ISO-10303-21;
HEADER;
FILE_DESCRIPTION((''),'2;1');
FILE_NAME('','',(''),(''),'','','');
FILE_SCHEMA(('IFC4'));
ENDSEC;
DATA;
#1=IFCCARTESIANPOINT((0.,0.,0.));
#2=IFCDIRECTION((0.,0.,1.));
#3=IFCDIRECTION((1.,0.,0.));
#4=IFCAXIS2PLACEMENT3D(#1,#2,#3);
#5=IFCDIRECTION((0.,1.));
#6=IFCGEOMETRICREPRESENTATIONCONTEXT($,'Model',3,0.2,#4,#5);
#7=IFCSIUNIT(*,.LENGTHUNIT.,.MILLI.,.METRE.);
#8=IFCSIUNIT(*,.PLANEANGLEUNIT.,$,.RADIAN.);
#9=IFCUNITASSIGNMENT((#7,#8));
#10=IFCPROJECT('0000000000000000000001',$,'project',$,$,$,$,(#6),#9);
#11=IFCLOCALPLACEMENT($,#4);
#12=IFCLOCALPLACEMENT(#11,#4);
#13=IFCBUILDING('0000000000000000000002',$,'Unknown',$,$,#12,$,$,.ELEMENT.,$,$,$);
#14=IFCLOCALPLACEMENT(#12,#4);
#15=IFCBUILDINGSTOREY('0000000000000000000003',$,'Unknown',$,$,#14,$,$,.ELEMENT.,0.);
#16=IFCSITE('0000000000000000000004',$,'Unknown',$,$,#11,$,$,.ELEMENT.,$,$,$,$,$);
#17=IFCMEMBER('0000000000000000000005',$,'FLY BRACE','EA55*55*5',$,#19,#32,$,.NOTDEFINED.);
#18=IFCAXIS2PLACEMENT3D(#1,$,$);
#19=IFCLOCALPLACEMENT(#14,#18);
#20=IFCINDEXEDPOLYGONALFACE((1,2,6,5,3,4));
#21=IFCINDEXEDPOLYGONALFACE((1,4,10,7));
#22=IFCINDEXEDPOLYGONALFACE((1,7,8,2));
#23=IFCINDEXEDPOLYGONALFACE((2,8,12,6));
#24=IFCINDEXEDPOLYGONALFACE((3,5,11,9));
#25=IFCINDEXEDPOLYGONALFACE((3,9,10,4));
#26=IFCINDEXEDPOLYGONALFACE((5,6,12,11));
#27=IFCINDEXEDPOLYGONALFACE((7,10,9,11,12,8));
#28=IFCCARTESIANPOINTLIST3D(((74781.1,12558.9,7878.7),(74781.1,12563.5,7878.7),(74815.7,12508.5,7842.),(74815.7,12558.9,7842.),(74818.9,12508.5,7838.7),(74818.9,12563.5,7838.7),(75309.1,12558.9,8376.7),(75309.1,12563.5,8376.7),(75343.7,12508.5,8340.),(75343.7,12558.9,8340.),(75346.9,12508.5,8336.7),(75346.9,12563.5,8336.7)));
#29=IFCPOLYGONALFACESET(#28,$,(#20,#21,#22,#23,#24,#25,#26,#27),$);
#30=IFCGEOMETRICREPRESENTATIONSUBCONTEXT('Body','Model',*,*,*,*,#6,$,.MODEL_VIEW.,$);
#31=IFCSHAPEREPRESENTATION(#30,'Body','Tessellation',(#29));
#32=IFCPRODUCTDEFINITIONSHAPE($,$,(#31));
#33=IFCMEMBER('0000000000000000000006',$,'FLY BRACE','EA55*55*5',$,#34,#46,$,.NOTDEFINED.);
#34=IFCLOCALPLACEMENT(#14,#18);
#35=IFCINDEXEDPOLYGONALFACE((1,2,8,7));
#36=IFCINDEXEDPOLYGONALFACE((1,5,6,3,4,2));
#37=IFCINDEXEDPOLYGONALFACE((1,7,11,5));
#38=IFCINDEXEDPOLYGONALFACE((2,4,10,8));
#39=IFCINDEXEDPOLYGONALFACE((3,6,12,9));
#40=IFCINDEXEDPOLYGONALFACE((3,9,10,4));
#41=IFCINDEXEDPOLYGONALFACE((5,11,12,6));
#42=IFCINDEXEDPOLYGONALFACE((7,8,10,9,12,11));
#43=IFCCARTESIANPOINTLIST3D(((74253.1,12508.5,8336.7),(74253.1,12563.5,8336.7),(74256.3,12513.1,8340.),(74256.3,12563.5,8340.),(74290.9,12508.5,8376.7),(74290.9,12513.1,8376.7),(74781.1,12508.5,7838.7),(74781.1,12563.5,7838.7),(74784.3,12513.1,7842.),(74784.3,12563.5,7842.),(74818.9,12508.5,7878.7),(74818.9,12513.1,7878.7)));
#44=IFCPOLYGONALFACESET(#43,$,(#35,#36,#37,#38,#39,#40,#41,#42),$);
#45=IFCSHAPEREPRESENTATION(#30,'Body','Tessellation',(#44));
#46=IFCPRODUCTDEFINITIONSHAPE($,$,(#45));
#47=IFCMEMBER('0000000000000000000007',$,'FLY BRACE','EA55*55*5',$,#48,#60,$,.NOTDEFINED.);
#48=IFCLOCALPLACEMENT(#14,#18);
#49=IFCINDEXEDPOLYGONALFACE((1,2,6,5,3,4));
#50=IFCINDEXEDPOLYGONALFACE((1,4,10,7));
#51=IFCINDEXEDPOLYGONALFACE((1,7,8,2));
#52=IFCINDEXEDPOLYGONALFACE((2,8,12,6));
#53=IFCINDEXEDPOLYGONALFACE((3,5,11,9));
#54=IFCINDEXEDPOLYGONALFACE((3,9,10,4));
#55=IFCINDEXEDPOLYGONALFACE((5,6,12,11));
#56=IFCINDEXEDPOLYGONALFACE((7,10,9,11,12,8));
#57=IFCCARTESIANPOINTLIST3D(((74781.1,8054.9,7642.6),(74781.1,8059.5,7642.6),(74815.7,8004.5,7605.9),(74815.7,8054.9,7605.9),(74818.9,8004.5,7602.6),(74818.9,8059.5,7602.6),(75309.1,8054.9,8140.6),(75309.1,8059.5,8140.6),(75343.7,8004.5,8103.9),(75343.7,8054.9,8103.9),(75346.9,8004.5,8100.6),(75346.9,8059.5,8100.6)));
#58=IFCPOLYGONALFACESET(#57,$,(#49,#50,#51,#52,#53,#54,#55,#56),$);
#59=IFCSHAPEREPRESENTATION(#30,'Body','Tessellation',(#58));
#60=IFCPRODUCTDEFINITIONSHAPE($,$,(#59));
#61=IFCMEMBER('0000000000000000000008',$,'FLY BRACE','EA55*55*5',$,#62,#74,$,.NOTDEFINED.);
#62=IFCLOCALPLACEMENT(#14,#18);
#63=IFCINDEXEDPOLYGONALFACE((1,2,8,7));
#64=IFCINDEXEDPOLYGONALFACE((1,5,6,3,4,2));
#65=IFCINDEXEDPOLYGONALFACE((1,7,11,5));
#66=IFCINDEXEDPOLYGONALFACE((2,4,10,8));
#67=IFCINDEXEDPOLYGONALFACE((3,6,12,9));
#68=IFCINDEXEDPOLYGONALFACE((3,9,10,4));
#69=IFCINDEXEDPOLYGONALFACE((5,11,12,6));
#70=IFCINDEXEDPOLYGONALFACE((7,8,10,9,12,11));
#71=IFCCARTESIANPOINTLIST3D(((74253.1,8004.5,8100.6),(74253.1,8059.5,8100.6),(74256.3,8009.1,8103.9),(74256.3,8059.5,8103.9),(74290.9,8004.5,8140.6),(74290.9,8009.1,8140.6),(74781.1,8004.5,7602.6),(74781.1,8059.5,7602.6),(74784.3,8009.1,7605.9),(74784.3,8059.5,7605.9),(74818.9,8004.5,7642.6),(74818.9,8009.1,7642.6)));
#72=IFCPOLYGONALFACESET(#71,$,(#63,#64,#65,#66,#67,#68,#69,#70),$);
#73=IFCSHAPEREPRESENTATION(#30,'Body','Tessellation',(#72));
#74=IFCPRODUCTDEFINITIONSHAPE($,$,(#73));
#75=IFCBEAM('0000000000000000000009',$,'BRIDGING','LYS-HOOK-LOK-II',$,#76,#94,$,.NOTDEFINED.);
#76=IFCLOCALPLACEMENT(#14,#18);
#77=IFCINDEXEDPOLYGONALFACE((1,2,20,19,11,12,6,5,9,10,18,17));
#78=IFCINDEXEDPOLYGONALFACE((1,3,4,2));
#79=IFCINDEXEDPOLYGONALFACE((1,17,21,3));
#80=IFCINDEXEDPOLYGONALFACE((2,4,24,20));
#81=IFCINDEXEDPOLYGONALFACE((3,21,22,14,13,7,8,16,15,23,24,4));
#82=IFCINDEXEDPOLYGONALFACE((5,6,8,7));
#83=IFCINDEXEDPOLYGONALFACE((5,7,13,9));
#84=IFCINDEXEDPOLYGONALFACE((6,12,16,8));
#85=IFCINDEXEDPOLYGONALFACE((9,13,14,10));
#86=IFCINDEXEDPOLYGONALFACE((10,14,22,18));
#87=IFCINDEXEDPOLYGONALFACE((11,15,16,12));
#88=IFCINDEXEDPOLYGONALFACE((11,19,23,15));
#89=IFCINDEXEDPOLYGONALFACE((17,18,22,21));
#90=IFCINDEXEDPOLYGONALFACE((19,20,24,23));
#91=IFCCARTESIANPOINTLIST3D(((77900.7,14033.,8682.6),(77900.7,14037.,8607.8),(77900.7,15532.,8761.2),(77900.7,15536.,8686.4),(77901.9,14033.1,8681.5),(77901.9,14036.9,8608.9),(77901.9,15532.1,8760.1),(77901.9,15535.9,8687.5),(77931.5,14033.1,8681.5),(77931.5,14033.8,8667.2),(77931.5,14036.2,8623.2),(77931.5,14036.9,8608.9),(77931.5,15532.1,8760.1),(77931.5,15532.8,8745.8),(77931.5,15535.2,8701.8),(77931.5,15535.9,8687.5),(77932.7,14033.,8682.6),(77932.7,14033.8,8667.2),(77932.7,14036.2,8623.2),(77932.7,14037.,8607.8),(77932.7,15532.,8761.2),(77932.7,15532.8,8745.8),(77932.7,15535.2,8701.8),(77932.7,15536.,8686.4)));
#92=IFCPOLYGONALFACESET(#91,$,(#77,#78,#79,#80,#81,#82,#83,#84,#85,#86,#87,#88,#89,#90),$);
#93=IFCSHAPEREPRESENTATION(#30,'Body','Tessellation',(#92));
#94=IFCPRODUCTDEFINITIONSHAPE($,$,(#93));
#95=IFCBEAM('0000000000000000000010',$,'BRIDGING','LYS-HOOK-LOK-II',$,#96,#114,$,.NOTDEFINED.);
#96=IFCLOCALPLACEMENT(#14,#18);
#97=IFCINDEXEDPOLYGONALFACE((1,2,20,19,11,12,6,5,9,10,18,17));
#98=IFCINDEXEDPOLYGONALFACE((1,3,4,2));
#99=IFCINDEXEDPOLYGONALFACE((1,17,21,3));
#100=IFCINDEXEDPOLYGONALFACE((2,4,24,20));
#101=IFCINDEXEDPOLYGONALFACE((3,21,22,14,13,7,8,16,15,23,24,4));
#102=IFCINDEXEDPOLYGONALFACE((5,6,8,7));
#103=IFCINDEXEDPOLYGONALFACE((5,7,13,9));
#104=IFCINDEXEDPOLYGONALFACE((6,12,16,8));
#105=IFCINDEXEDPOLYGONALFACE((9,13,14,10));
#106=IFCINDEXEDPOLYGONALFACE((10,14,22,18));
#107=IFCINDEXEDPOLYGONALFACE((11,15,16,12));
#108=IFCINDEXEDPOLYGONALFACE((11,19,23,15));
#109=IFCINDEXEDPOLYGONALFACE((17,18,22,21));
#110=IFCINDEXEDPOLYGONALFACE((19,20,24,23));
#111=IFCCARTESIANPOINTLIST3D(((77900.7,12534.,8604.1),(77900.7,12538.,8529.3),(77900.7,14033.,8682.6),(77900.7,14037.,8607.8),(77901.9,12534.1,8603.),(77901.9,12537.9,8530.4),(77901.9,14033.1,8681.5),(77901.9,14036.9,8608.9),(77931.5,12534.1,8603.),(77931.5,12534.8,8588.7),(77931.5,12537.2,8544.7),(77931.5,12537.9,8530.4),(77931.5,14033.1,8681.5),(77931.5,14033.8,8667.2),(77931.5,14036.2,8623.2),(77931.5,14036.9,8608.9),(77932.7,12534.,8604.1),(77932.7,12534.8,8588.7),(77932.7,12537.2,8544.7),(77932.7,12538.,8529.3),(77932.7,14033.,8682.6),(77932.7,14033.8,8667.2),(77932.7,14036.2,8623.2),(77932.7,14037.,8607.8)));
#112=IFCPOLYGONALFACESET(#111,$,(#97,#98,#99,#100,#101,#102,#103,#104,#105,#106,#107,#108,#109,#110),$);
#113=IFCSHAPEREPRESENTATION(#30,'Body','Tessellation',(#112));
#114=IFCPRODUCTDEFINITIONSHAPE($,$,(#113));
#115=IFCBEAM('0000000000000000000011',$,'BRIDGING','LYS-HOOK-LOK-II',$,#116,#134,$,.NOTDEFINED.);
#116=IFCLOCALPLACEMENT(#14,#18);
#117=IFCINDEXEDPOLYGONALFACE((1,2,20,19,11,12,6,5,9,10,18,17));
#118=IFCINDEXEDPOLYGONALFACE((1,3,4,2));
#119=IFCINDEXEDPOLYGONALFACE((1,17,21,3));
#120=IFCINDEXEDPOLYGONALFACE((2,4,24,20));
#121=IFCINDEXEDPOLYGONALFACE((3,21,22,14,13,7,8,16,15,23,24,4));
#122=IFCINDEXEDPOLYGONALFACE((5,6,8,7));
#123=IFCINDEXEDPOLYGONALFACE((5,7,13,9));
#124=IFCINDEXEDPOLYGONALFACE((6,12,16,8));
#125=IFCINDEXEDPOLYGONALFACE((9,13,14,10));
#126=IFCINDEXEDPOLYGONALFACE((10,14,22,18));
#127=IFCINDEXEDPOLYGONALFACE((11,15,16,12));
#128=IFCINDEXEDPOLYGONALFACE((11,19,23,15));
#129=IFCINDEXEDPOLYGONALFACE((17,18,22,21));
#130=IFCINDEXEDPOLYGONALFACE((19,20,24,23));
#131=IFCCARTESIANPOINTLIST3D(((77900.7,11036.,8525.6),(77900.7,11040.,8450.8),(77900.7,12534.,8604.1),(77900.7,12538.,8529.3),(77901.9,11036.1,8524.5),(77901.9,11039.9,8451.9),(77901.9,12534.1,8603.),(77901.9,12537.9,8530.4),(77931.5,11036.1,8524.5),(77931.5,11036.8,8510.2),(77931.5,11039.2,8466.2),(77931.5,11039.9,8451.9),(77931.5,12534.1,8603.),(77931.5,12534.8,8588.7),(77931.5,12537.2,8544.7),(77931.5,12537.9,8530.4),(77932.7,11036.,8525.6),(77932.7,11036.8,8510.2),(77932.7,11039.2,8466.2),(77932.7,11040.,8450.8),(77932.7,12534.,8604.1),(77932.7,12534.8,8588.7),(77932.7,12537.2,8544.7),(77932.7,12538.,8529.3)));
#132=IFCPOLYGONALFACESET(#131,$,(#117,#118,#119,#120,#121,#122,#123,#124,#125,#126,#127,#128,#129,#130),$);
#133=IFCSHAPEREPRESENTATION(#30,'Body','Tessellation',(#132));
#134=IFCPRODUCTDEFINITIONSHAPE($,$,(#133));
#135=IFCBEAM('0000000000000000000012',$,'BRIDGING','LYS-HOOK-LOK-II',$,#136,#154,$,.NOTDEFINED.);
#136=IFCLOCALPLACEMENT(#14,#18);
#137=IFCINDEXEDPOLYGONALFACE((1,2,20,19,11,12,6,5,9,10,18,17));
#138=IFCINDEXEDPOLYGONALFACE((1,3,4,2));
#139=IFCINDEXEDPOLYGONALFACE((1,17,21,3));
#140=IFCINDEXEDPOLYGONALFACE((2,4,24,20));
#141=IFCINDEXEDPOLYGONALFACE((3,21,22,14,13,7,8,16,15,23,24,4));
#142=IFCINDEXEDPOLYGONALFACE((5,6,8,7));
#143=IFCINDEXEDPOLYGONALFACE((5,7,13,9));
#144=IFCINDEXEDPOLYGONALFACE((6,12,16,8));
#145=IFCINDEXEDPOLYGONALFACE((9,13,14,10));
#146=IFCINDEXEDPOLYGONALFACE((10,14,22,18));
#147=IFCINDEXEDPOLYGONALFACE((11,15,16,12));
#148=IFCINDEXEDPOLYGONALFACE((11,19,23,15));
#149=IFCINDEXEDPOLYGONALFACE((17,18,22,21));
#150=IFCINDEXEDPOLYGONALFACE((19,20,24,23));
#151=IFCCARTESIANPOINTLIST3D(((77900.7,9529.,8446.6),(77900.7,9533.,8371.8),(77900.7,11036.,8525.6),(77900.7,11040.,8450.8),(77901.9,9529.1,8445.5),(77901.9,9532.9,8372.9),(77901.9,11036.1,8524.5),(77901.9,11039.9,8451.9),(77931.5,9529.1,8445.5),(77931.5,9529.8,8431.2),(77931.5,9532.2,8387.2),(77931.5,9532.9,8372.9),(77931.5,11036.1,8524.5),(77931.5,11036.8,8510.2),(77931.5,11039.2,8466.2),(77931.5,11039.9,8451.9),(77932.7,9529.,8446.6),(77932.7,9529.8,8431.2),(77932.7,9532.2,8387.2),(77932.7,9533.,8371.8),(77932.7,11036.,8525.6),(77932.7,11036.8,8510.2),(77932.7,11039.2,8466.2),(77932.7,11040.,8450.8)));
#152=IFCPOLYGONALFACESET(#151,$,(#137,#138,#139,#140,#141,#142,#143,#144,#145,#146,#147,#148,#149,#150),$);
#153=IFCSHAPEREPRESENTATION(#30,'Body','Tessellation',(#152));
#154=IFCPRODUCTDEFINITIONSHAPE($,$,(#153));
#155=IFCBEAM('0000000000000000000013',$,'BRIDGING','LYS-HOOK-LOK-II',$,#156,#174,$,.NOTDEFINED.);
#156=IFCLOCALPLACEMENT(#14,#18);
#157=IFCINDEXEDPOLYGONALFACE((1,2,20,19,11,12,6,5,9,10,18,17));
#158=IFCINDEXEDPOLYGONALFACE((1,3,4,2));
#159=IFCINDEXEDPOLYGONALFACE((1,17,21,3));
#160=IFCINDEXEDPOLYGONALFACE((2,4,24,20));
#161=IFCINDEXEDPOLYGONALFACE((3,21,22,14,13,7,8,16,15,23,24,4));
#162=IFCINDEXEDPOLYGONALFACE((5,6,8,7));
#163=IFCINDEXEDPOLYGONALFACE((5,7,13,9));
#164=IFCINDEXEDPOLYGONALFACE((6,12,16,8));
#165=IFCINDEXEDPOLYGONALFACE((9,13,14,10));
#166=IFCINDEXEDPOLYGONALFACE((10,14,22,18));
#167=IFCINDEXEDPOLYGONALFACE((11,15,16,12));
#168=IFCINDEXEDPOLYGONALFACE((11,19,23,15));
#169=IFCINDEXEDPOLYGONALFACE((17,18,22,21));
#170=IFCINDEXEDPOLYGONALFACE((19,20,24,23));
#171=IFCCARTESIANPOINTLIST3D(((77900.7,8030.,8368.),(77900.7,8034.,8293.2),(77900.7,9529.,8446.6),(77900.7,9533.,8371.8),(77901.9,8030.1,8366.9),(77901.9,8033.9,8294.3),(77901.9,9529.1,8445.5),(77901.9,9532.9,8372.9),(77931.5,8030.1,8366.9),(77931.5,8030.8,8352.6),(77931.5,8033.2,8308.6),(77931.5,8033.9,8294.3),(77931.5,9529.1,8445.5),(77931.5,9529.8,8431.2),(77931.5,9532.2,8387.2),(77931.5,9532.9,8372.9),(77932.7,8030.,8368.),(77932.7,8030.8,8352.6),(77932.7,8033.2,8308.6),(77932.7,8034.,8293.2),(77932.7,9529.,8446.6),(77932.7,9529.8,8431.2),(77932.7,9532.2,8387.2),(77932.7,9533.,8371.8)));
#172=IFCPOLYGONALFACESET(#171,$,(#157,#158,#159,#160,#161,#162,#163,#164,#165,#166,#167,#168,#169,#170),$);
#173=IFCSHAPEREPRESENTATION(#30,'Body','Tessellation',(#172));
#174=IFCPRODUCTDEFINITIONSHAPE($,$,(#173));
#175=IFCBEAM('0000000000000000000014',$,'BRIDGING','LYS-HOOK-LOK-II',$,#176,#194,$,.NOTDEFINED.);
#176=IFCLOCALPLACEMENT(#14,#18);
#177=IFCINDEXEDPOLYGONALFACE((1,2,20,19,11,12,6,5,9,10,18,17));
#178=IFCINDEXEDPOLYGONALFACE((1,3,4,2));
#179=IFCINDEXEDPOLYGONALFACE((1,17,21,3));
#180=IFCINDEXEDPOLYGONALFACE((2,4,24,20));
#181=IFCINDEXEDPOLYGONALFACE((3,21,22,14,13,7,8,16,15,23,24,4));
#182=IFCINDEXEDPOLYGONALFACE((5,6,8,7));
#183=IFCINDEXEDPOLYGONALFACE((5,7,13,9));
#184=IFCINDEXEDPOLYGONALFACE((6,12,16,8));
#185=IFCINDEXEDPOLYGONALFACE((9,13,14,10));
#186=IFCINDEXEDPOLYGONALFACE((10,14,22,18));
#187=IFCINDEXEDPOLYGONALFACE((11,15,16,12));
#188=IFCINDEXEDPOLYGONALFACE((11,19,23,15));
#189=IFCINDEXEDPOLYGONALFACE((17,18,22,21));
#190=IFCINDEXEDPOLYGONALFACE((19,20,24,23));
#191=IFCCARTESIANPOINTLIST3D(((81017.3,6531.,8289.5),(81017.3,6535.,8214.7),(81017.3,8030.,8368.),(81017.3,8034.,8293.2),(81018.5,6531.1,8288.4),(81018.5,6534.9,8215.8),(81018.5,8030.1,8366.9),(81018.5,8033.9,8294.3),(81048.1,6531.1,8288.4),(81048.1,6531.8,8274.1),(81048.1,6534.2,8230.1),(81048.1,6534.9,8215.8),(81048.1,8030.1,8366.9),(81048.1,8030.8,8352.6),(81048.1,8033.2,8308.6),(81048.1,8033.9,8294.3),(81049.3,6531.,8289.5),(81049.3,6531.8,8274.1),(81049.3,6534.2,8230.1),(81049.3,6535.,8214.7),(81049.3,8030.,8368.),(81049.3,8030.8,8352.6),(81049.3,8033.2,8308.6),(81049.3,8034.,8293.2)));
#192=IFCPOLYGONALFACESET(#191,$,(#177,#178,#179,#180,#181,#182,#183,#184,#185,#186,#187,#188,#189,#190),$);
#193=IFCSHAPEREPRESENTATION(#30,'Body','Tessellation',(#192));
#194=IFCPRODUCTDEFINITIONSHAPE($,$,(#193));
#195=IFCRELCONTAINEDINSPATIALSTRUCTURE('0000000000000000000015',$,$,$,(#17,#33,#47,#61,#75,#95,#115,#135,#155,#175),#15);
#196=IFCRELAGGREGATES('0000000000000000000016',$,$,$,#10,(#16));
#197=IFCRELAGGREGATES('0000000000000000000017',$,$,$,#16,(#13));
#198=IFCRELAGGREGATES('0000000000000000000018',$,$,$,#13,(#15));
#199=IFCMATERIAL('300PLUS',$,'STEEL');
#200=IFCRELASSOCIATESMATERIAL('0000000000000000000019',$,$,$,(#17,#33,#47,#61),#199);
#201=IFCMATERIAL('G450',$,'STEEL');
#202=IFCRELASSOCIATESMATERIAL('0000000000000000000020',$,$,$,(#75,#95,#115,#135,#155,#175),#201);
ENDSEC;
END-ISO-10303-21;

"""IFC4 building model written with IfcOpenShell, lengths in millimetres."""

from ifc_helpers import new_model, si_unit, direction, frame, origin_with_axes, place, context, subcontext, project, spatial, line, indexed_curve, outline, extrude, material, element, save


model = new_model("IFC4")

# Units and contexts
model_context = context("Model", 3, precision=0.2, world=origin_with_axes(), true_north=direction((0.0, 1.0)))
body_context = subcontext(model_context, "Body", "Model", "MODEL_VIEW")
ifc_project = project(units=[si_unit("LENGTHUNIT", "METRE", prefix="MILLI"), si_unit("PLANEANGLEUNIT", "RADIAN")], contexts=[model_context])

# Site, building, storey
site_placement = place(None, origin_with_axes())
site = spatial("IfcSite", under=ifc_project, at=site_placement, Name="Unknown", CompositionType="ELEMENT")
building_placement = place(site_placement, origin_with_axes())
building = spatial("IfcBuilding", under=site, at=building_placement, Name="Unknown", CompositionType="ELEMENT")
storey_placement = place(building_placement, origin_with_axes())
storey = spatial("IfcBuildingStorey", under=building, at=storey_placement, Name="Unknown", CompositionType="ELEMENT", Elevation=0.0)

# Members
ifc_material_1 = material(Name="300PLUS", Category="STEEL")
for number, where, z_axis, x_axis, name in (
    (1, (75328.0, 12536.0, 8356.7), (-0.686138, 0.0, 0.727472), (-0.727472, 0.0, -0.686138), "FLY BRACE"),
    (2, (74272.0, 12536.0, 8356.7), (0.686138, 0.0, 0.727472), (0.727472, 0.0, -0.686138), "FLY BRACE"),
    (3, (75328.0, 8032.0, 8120.6), (-0.686138, 0.0, 0.727472), (-0.727472, 0.0, -0.686138), "FLY BRACE"),
    (4, (74272.0, 8032.0, 8120.6), (0.686138, 0.0, 0.727472), (0.727472, 0.0, -0.686138), "FLY BRACE"),
):
    element("IfcMember", number, at=place(storey_placement, frame(where, z_axis=z_axis, x_axis=x_axis)), inside=storey, material=ifc_material_1, Name=name, Description="EA55*55*5", PredefinedType="NOTDEFINED", context=body_context, shape_type="SolidModel", body=[
        extrude(outline(indexed_curve([(-27.5, -27.5), (27.5, -27.5), (27.5, -22.9), (-22.9, -22.9), (-22.9, 27.5), (-27.5, 27.5)], segments=[line(1, 2, 3, 4, 5, 6, 1)])), frame((0.0, 0.0, 0.0), z_axis=(-1.0, 0.0, 0.0), x_axis=(0.0, 0.0, 1.0)), (0.0, 0.0, -1.0), 725.8),
    ])

# Beams
ifc_material_2 = material(Name="G450", Category="STEEL")
beam_1_placement = place(storey_placement, frame((77916.7, 14035.0, 8645.2), z_axis=(1.0, 0.0, 0.0), x_axis=(0.0, 0.998628, 0.052363)))
element("IfcBeam", 5, at=beam_1_placement, inside=storey, material=ifc_material_2, Name="BRIDGING", Description="LYS-HOOK-LOK-II", PredefinedType="NOTDEFINED", context=body_context, shape_type="SolidModel", body=[
    extrude(outline(indexed_curve([(16.0, -37.5), (16.0, -22.0), (14.8, -22.0), (14.8, -36.3), (-14.8, -36.3), (-14.8, 36.3), (14.8, 36.3), (14.8, 22.0), (16.0, 22.0), (16.0, 37.5), (-16.0, 37.5), (-16.0, -37.5)], segments=[line(1, 2, 3, 4, 5, 6, 7, 8, 9, 10, 11, 12, 1)])), frame((0.0, 0.0, 0.0), z_axis=(-1.0, 0.0, 0.0), x_axis=(0.0, 0.0, 1.0)), (0.0, 0.0, -1.0), 1501.1),
])
beam_2_placement = place(storey_placement, frame((77916.7, 12536.0, 8566.7), z_axis=(1.0, 0.0, 0.0), x_axis=(0.0, 0.998632, 0.052297)))
element("IfcBeam", 6, at=beam_2_placement, inside=storey, material=ifc_material_2, Name="BRIDGING", Description="LYS-HOOK-LOK-II", PredefinedType="NOTDEFINED", context=body_context, shape_type="SolidModel", body=[
    extrude(outline(indexed_curve([(16.0, -37.5), (16.0, -22.0), (14.8, -22.0), (14.8, -36.3), (-14.8, -36.3), (-14.8, 36.3), (14.8, 36.3), (14.8, 22.0), (16.0, 22.0), (16.0, 37.5), (-16.0, 37.5), (-16.0, -37.5)], segments=[line(1, 2, 3, 4, 5, 6, 7, 8, 9, 10, 11, 12, 1)])), frame((0.0, 0.0, 0.0), z_axis=(-1.0, 0.0, 0.0), x_axis=(0.0, 0.0, 1.0)), (0.0, 0.0, -1.0), 1501.1),
])
beam_3_placement = place(storey_placement, frame((77916.7, 11038.0, 8488.2), z_axis=(1.0, 0.0, 0.0), x_axis=(0.0, 0.99863, 0.052331)))
element("IfcBeam", 7, at=beam_3_placement, inside=storey, material=ifc_material_2, Name="BRIDGING", Description="LYS-HOOK-LOK-II", PredefinedType="NOTDEFINED", context=body_context, shape_type="SolidModel", body=[
    extrude(outline(indexed_curve([(16.0, -37.5), (16.0, -22.0), (14.8, -22.0), (14.8, -36.3), (-14.8, -36.3), (-14.8, 36.3), (14.8, 36.3), (14.8, 22.0), (16.0, 22.0), (16.0, 37.5), (-16.0, 37.5), (-16.0, -37.5)], segments=[line(1, 2, 3, 4, 5, 6, 7, 8, 9, 10, 11, 12, 1)])), frame((0.0, 0.0, 0.0), z_axis=(-1.0, 0.0, 0.0), x_axis=(0.0, 0.0, 1.0)), (0.0, 0.0, -1.0), 1500.1),
])
beam_4_placement = place(storey_placement, frame((77916.7, 9531.0, 8409.2), z_axis=(1.0, 0.0, 0.0), x_axis=(0.0, 0.998629, 0.05235)))
element("IfcBeam", 8, at=beam_4_placement, inside=storey, material=ifc_material_2, Name="BRIDGING", Description="LYS-HOOK-LOK-II", PredefinedType="NOTDEFINED", context=body_context, shape_type="SolidModel", body=[
    extrude(outline(indexed_curve([(16.0, -37.5), (16.0, -22.0), (14.8, -22.0), (14.8, -36.3), (-14.8, -36.3), (-14.8, 36.3), (14.8, 36.3), (14.8, 22.0), (16.0, 22.0), (16.0, 37.5), (-16.0, 37.5), (-16.0, -37.5)], segments=[line(1, 2, 3, 4, 5, 6, 7, 8, 9, 10, 11, 12, 1)])), frame((0.0, 0.0, 0.0), z_axis=(-1.0, 0.0, 0.0), x_axis=(0.0, 0.0, 1.0)), (0.0, 0.0, -1.0), 1509.1),
])
beam_5_placement = place(storey_placement, frame((77916.7, 8032.0, 8330.6), z_axis=(1.0, 0.0, 0.0), x_axis=(0.0, 0.998628, 0.052363)))
element("IfcBeam", 9, at=beam_5_placement, inside=storey, material=ifc_material_2, Name="BRIDGING", Description="LYS-HOOK-LOK-II", PredefinedType="NOTDEFINED", context=body_context, shape_type="SolidModel", body=[
    extrude(outline(indexed_curve([(16.0, -37.5), (16.0, -22.0), (14.8, -22.0), (14.8, -36.3), (-14.8, -36.3), (-14.8, 36.3), (14.8, 36.3), (14.8, 22.0), (16.0, 22.0), (16.0, 37.5), (-16.0, 37.5), (-16.0, -37.5)], segments=[line(1, 2, 3, 4, 5, 6, 7, 8, 9, 10, 11, 12, 1)])), frame((0.0, 0.0, 0.0), z_axis=(-1.0, 0.0, 0.0), x_axis=(0.0, 0.0, 1.0)), (0.0, 0.0, -1.0), 1501.1),
])
beam_6_placement = place(storey_placement, frame((81033.3, 6533.0, 8252.1), z_axis=(1.0, 0.0, 0.0), x_axis=(0.0, 0.998632, 0.052297)))
element("IfcBeam", 10, at=beam_6_placement, inside=storey, material=ifc_material_2, Name="BRIDGING", Description="LYS-HOOK-LOK-II", PredefinedType="NOTDEFINED", context=body_context, shape_type="SolidModel", body=[
    extrude(outline(indexed_curve([(16.0, -37.5), (16.0, -22.0), (14.8, -22.0), (14.8, -36.3), (-14.8, -36.3), (-14.8, 36.3), (14.8, 36.3), (14.8, 22.0), (16.0, 22.0), (16.0, 37.5), (-16.0, 37.5), (-16.0, -37.5)], segments=[line(1, 2, 3, 4, 5, 6, 7, 8, 9, 10, 11, 12, 1)])), frame((0.0, 0.0, 0.0), z_axis=(-1.0, 0.0, 0.0), x_axis=(0.0, 0.0, 1.0)), (0.0, 0.0, -1.0), 1501.1),
])

save(model, "model.ifc")
